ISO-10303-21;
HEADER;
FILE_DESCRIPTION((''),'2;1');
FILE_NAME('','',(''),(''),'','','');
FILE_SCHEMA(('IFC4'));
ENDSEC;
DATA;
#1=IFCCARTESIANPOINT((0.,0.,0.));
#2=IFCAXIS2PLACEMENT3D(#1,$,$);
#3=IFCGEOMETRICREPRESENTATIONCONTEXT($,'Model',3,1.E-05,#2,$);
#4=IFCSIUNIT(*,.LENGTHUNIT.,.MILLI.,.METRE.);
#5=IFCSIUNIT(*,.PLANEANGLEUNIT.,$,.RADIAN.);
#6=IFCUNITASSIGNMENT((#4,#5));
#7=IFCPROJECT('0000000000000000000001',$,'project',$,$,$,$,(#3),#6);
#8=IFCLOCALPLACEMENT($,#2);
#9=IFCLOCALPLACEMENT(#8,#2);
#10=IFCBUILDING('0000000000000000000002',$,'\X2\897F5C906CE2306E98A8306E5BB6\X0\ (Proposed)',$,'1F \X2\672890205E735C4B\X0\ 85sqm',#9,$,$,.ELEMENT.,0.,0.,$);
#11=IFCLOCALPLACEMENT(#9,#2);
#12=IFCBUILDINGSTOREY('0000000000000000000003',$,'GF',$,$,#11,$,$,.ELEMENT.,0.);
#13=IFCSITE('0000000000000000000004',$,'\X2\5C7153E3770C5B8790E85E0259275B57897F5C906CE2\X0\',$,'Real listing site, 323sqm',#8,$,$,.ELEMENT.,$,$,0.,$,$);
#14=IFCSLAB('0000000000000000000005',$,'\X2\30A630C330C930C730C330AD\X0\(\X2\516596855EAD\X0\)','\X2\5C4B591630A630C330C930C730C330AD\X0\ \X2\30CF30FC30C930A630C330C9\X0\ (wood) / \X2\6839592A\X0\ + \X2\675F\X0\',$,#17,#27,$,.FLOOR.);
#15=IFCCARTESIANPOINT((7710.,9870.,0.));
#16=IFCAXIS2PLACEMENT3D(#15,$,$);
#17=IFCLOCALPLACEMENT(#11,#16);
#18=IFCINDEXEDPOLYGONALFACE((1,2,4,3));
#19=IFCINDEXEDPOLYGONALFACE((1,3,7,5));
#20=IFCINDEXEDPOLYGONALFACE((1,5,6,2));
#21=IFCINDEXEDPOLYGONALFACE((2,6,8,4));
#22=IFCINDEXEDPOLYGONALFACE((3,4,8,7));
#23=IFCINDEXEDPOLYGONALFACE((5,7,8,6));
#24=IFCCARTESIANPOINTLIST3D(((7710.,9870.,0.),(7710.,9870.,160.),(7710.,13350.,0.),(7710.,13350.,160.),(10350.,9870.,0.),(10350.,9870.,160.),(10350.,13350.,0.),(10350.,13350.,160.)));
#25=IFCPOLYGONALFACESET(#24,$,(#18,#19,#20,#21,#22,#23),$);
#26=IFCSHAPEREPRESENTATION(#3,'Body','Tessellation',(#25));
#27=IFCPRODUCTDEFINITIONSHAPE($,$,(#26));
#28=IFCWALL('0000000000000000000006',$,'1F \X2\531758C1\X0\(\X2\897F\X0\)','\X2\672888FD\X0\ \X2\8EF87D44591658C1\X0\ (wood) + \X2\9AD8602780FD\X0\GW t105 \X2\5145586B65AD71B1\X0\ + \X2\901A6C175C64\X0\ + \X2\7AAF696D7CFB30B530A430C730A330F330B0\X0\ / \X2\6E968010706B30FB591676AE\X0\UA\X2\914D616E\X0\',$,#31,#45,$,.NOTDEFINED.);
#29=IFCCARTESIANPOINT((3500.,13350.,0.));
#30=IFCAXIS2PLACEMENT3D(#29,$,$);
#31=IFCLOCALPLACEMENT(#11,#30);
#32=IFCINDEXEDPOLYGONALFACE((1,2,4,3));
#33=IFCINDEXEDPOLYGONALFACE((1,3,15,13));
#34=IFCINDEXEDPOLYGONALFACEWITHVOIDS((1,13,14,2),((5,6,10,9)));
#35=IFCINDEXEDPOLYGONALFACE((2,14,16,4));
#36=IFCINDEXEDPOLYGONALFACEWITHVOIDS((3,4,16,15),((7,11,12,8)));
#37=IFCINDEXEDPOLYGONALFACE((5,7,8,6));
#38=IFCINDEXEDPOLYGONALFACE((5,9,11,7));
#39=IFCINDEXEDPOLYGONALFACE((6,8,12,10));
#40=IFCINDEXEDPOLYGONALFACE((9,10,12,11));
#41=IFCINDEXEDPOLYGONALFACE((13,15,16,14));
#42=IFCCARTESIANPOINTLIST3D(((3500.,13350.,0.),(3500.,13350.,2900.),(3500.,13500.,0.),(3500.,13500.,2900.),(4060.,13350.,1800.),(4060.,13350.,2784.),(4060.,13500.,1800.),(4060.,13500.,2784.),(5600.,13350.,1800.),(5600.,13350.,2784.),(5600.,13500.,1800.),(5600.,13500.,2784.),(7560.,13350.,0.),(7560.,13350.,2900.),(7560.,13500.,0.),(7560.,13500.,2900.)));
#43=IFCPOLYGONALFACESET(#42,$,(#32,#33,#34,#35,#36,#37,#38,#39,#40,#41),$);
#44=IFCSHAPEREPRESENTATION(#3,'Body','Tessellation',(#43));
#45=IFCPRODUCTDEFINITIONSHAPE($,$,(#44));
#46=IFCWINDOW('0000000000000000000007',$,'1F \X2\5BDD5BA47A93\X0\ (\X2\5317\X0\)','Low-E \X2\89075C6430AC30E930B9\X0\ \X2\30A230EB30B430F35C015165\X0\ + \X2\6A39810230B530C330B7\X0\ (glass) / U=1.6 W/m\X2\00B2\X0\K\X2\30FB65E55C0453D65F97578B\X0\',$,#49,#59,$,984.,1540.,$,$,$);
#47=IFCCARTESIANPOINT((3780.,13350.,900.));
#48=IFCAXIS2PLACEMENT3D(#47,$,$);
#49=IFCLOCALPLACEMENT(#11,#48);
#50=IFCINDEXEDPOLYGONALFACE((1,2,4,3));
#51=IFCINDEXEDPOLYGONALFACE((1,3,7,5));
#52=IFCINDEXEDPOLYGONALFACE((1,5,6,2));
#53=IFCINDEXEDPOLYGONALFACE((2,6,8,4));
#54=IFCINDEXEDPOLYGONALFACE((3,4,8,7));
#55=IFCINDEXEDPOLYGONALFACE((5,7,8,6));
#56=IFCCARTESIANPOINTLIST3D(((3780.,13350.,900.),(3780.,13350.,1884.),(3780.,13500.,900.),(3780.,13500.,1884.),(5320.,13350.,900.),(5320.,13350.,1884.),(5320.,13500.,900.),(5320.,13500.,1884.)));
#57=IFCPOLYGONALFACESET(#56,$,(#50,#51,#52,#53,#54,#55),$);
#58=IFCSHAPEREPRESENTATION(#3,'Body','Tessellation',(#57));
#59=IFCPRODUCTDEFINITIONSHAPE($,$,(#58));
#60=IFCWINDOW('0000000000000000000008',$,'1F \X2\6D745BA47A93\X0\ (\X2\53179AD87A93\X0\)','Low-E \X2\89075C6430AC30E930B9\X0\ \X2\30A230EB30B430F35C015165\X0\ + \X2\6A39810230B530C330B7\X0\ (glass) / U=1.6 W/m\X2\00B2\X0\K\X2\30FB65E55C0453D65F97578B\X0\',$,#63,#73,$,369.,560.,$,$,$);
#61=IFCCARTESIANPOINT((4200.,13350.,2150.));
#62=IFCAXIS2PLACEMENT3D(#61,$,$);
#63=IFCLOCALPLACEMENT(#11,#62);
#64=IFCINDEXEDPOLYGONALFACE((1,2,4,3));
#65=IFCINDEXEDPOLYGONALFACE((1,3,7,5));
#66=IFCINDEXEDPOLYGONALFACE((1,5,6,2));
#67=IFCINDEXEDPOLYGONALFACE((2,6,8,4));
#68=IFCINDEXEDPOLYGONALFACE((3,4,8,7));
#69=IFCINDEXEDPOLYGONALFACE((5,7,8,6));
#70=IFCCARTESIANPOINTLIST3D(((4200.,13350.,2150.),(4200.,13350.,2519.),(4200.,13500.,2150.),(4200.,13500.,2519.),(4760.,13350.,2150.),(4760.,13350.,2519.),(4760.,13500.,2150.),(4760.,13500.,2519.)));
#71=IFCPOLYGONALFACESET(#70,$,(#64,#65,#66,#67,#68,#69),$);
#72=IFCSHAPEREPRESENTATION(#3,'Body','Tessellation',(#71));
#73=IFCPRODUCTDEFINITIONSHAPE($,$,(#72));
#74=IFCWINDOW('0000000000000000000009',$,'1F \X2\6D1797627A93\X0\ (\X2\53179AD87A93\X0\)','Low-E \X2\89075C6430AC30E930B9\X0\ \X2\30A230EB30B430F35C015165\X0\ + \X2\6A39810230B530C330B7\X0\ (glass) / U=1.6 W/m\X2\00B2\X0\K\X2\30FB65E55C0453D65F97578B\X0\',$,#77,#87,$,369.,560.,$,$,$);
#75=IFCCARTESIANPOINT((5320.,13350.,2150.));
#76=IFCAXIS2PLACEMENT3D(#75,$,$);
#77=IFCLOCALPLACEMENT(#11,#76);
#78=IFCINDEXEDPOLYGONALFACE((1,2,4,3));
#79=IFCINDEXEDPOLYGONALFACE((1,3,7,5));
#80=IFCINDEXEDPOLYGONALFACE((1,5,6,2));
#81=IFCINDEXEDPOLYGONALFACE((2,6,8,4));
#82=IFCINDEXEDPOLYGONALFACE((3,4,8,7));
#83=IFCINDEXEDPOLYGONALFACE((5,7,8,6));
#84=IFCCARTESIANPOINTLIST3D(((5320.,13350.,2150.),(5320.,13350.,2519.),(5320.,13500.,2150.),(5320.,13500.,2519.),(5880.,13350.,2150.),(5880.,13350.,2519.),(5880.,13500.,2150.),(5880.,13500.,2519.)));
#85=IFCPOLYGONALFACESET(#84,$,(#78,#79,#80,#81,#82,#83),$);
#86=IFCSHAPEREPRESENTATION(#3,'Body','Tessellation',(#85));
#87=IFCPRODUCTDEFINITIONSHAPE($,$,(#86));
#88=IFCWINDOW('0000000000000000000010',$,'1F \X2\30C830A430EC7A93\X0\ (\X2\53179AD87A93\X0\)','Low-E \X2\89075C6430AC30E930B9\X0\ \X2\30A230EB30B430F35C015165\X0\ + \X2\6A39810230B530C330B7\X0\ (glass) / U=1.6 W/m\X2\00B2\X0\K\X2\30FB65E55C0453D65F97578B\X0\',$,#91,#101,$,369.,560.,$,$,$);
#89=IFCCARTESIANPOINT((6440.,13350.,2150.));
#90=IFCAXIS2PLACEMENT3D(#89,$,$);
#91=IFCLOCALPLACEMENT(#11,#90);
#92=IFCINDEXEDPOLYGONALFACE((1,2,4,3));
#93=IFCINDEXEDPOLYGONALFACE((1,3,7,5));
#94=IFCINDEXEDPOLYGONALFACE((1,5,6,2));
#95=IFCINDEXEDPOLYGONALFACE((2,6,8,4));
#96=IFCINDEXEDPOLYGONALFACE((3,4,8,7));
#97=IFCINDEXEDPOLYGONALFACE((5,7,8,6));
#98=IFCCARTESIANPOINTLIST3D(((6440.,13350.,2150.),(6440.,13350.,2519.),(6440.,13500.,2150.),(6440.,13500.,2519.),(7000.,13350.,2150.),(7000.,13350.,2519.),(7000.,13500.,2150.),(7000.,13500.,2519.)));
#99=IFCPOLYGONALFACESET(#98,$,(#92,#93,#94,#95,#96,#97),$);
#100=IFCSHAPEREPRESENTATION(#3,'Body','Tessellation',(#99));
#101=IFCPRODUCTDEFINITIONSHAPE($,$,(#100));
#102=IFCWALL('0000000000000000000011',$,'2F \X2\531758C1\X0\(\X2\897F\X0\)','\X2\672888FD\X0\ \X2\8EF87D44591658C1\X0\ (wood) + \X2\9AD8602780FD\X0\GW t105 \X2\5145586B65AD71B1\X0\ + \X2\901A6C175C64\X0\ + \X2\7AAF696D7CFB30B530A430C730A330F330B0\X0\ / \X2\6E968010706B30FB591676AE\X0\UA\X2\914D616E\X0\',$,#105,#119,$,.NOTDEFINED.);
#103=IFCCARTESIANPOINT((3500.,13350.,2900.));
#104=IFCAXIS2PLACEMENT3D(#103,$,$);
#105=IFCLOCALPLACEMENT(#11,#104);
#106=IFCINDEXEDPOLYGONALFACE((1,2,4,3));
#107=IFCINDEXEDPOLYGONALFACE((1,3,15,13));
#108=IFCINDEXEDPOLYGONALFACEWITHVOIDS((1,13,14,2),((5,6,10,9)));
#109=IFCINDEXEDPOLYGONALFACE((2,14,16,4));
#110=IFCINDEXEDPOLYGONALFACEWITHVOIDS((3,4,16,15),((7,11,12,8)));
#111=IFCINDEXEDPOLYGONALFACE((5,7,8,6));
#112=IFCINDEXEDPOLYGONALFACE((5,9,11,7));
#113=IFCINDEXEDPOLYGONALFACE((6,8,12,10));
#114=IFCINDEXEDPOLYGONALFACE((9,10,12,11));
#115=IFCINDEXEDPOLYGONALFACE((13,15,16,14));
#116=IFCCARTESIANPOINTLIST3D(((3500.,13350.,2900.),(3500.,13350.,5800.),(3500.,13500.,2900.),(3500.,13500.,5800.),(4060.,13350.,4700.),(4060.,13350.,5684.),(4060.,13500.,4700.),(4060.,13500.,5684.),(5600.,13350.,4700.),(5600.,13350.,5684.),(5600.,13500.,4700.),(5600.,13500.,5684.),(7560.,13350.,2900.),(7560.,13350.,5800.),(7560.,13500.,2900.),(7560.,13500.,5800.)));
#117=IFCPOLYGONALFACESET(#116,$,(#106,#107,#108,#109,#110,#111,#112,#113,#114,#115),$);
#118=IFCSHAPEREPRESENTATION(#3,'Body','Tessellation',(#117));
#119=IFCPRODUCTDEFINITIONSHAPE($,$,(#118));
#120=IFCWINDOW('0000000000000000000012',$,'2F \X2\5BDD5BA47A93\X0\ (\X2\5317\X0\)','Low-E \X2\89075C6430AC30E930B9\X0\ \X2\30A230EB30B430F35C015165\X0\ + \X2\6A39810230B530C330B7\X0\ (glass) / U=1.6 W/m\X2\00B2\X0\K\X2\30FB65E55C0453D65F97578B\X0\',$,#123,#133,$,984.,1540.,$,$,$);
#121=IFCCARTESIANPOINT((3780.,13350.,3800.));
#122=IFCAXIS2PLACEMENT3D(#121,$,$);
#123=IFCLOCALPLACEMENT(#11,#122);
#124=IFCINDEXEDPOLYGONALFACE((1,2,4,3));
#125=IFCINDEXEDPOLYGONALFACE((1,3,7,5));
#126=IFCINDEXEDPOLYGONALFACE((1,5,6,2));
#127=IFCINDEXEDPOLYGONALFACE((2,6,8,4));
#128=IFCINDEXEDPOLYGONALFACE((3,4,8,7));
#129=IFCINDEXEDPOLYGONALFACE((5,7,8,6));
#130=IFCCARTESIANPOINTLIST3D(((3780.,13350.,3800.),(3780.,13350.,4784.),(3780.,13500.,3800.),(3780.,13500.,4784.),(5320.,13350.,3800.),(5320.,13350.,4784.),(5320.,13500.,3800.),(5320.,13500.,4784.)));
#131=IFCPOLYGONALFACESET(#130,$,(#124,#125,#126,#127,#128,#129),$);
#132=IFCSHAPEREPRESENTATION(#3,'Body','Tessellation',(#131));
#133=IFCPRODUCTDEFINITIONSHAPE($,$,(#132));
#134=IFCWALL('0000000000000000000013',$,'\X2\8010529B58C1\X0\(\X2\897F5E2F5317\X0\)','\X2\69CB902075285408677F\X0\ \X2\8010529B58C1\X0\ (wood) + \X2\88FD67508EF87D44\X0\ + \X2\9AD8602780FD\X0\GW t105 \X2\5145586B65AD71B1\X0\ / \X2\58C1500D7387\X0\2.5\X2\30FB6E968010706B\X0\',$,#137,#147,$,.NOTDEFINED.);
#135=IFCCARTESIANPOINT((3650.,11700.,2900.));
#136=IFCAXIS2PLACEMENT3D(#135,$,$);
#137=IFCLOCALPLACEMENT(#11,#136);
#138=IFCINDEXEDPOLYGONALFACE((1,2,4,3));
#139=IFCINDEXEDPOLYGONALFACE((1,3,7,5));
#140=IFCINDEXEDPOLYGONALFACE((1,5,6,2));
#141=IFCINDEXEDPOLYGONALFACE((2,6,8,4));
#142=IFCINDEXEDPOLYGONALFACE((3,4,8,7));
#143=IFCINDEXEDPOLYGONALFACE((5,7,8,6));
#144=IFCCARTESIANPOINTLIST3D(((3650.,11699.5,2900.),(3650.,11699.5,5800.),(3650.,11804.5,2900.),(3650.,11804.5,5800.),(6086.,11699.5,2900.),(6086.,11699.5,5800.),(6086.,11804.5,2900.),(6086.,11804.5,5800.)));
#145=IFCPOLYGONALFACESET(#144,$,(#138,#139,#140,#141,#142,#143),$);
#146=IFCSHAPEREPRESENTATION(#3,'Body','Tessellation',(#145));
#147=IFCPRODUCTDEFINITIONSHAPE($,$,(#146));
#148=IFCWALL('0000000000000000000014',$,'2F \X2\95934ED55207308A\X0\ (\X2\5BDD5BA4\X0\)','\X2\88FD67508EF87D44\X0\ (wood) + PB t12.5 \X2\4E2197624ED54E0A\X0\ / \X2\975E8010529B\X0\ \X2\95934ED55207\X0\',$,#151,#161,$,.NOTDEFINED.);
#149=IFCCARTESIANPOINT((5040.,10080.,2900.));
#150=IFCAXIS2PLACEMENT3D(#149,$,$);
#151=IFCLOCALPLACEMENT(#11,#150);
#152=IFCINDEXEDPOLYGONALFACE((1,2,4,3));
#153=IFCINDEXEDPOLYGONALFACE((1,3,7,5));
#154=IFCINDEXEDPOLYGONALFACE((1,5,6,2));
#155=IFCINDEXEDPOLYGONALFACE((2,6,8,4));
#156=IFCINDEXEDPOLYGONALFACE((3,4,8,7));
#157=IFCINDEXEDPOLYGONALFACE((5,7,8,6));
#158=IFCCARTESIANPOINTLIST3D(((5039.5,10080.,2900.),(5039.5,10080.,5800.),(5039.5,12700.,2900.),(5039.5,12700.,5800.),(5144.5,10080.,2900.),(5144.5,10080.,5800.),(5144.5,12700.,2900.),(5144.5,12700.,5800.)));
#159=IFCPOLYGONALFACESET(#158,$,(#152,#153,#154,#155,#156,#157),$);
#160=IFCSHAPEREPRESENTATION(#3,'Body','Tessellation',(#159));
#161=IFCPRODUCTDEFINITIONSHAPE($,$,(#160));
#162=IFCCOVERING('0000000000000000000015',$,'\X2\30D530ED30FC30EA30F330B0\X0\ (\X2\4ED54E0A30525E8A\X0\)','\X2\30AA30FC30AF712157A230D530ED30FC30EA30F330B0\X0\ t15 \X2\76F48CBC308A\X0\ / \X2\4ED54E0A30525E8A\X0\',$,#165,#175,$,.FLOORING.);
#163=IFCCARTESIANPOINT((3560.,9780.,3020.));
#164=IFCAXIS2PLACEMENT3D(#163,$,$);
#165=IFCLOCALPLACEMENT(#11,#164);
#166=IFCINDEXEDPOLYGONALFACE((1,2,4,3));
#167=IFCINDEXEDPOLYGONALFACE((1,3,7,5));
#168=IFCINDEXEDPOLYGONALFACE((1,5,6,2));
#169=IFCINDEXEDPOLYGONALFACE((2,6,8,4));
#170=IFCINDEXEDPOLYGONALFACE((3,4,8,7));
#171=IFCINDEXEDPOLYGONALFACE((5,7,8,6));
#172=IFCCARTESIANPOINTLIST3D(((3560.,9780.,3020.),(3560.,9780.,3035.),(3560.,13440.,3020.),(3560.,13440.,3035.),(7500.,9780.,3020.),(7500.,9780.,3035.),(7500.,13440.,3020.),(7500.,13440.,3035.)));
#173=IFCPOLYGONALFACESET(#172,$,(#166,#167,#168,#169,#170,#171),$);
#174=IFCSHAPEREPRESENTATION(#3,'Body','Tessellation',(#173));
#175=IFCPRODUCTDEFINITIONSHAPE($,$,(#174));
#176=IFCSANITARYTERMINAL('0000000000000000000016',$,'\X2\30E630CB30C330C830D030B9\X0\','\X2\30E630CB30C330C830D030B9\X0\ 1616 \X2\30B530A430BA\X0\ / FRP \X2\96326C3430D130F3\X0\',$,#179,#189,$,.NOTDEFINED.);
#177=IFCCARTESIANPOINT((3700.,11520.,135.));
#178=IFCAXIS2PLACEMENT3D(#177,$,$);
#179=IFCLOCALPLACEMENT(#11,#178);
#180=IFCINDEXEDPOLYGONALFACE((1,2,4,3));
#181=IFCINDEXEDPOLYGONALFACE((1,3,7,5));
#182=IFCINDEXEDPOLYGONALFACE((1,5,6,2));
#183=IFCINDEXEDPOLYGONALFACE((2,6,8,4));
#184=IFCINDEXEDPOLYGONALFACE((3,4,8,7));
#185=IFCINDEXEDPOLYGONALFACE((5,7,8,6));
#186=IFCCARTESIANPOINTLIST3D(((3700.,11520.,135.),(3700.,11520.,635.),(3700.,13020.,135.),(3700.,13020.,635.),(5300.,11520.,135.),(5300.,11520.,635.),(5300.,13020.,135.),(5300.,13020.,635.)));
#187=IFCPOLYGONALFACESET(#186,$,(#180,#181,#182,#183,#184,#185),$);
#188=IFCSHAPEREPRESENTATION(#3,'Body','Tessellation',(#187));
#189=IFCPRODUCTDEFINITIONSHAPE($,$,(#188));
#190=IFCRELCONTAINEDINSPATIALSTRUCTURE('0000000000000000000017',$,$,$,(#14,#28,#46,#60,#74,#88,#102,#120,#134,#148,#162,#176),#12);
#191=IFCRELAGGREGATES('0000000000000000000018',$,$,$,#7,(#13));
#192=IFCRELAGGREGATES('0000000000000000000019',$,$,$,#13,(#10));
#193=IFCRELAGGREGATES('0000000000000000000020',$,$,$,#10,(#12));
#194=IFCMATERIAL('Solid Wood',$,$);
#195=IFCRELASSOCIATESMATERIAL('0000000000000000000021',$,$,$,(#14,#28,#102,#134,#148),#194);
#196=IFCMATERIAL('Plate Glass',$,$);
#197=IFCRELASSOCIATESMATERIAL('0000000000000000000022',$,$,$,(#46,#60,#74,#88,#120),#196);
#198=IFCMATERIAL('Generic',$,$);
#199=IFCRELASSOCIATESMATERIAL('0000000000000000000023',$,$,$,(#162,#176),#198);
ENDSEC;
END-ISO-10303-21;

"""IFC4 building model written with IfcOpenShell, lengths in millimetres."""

from ifc_helpers import new_model, si_unit, frame, frame_2d, origin, place, context, project, spatial, rectangle, extrude, material, element, fill, save


model = new_model("IFC4")

# Units and contexts
model_context = context("Model", 3, precision=1e-05, world=origin())
ifc_project = project(units=[si_unit("LENGTHUNIT", "METRE", prefix="MILLI"), si_unit("PLANEANGLEUNIT", "RADIAN")], contexts=[model_context])

# Site, building, storey
site_placement = place(None, origin())
site = spatial("IfcSite", under=ifc_project, at=site_placement, Name="山口県宇部市大字西岐波", ObjectType="Real listing site, 323sqm", CompositionType="ELEMENT", RefElevation=0.0)
building_placement = place(site_placement, origin())
building = spatial("IfcBuilding", under=site, at=building_placement, Name="西岐波の風の家 (Proposed)", ObjectType="1F 木造平屋 85sqm", CompositionType="ELEMENT", ElevationOfRefHeight=0.0, ElevationOfTerrain=0.0)
storey_placement = place(building_placement, origin())
storey = spatial("IfcBuildingStorey", under=building, at=storey_placement, Name="GF", CompositionType="ELEMENT", Elevation=0.0)

# Slab
ifc_material_1 = material(Name="Solid Wood")
slab_placement = place(storey_placement, frame((7710.0, 9870.0, 0.0)))
element("IfcSlab", 1, at=slab_placement, inside=storey, material=ifc_material_1, Name="ウッドデッキ(入隅庭)", Description="屋外ウッドデッキ ハードウッド (wood) / 根太 + 束", PredefinedType="FLOOR", context=model_context, shape_type="SweptSolid", body=[
    extrude(rectangle(XDim=2640.0, YDim=3480.0, at=frame_2d((1320.0, 1740.0))), frame((7710.0, 9870.0, 0.0)), (0.0, 0.0, 1.0), 160.0),
])

# Wall, openings, windows
wall_1_placement = place(storey_placement, frame((3500.0, 13350.0, 0.0)))
wall_1 = element("IfcWall", 2, at=wall_1_placement, inside=storey, material=ifc_material_1, Name="1F 北壁(西)", Description="木製 軸組外壁 (wood) + 高性能GW t105 充填断熱 + 通気層 + 窯業系サイディング / 準耐火・外皮UA配慮", PredefinedType="NOTDEFINED", context=model_context, shape_type="SweptSolid", body=[
    extrude(rectangle(XDim=4060.0, YDim=150.0, at=frame_2d((2030.0, 75.0))), frame((3500.0, 13350.0, 0.0)), (0.0, 0.0, 1.0), 2900.0),
])
opening_1_placement = place(storey_placement, frame((3780.0, 13350.0, 900.0)))
opening_1 = element("IfcOpeningElement", 3, at=opening_1_placement, cuts=wall_1, PredefinedType="NOTDEFINED", context=model_context, shape_type="SweptSolid", body=[
    extrude(rectangle(XDim=1540.0, YDim=150.0, at=frame_2d((770.0, 75.0))), frame((3780.0, 13350.0, 900.0)), (0.0, 0.0, 1.0), 984.0),
])
opening_2_placement = place(storey_placement, frame((4200.0, 13350.0, 2150.0)))
opening_2 = element("IfcOpeningElement", 4, at=opening_2_placement, cuts=wall_1, PredefinedType="NOTDEFINED", context=model_context, shape_type="SweptSolid", body=[
    extrude(rectangle(XDim=560.0, YDim=150.0, at=frame_2d((280.0, 75.0))), frame((4200.0, 13350.0, 2150.0)), (0.0, 0.0, 1.0), 369.0),
])
opening_3_placement = place(storey_placement, frame((5320.0, 13350.0, 2150.0)))
opening_3 = element("IfcOpeningElement", 5, at=opening_3_placement, cuts=wall_1, PredefinedType="NOTDEFINED", context=model_context, shape_type="SweptSolid", body=[
    extrude(rectangle(XDim=560.0, YDim=150.0, at=frame_2d((280.0, 75.0))), frame((5320.0, 13350.0, 2150.0)), (0.0, 0.0, 1.0), 369.0),
])
opening_4_placement = place(storey_placement, frame((6440.0, 13350.0, 2150.0)))
opening_4 = element("IfcOpeningElement", 6, at=opening_4_placement, cuts=wall_1, PredefinedType="NOTDEFINED", context=model_context, shape_type="SweptSolid", body=[
    extrude(rectangle(XDim=560.0, YDim=150.0, at=frame_2d((280.0, 75.0))), frame((6440.0, 13350.0, 2150.0)), (0.0, 0.0, 1.0), 369.0),
])
ifc_material_2 = material(Name="Plate Glass")
window_1_placement = place(storey_placement, frame((3780.0, 13350.0, 900.0)))
window_1 = element("IfcWindow", 7, at=window_1_placement, inside=storey, material=ifc_material_2, Name="1F 寝室窓 (北)", Description="Low-E 複層ガラス アルゴン封入 + 樹脂サッシ (glass) / U=1.6 W/m²K・日射取得型", OverallHeight=984.0, OverallWidth=1540.0, context=model_context, shape_type="SweptSolid", body=[
    extrude(rectangle(XDim=1540.0, YDim=150.0, at=frame_2d((770.0, 75.0))), frame((3780.0, 13350.0, 900.0)), (0.0, 0.0, 1.0), 984.0),
])
fill(opening_1, window_1)
window_2_placement = place(storey_placement, frame((4200.0, 13350.0, 2150.0)))
window_2 = element("IfcWindow", 8, at=window_2_placement, inside=storey, material=ifc_material_2, Name="1F 浴室窓 (北高窓)", Description="Low-E 複層ガラス アルゴン封入 + 樹脂サッシ (glass) / U=1.6 W/m²K・日射取得型", OverallHeight=369.0, OverallWidth=560.0, context=model_context, shape_type="SweptSolid", body=[
    extrude(rectangle(XDim=560.0, YDim=150.0, at=frame_2d((280.0, 75.0))), frame((4200.0, 13350.0, 2150.0)), (0.0, 0.0, 1.0), 369.0),
])
fill(opening_2, window_2)
window_3_placement = place(storey_placement, frame((5320.0, 13350.0, 2150.0)))
window_3 = element("IfcWindow", 9, at=window_3_placement, inside=storey, material=ifc_material_2, Name="1F 洗面窓 (北高窓)", Description="Low-E 複層ガラス アルゴン封入 + 樹脂サッシ (glass) / U=1.6 W/m²K・日射取得型", OverallHeight=369.0, OverallWidth=560.0, context=model_context, shape_type="SweptSolid", body=[
    extrude(rectangle(XDim=560.0, YDim=150.0, at=frame_2d((280.0, 75.0))), frame((5320.0, 13350.0, 2150.0)), (0.0, 0.0, 1.0), 369.0),
])
fill(opening_3, window_3)
window_4_placement = place(storey_placement, frame((6440.0, 13350.0, 2150.0)))
window_4 = element("IfcWindow", 10, at=window_4_placement, inside=storey, material=ifc_material_2, Name="1F トイレ窓 (北高窓)", Description="Low-E 複層ガラス アルゴン封入 + 樹脂サッシ (glass) / U=1.6 W/m²K・日射取得型", OverallHeight=369.0, OverallWidth=560.0, context=model_context, shape_type="SweptSolid", body=[
    extrude(rectangle(XDim=560.0, YDim=150.0, at=frame_2d((280.0, 75.0))), frame((6440.0, 13350.0, 2150.0)), (0.0, 0.0, 1.0), 369.0),
])
fill(opening_4, window_4)

# Wall, opening, window
wall_2_placement = place(storey_placement, frame((3500.0, 13350.0, 2900.0)))
wall_2 = element("IfcWall", 11, at=wall_2_placement, inside=storey, material=ifc_material_1, Name="2F 北壁(西)", Description="木製 軸組外壁 (wood) + 高性能GW t105 充填断熱 + 通気層 + 窯業系サイディング / 準耐火・外皮UA配慮", PredefinedType="NOTDEFINED", context=model_context, shape_type="SweptSolid", body=[
    extrude(rectangle(XDim=4060.0, YDim=150.0, at=frame_2d((2030.0, 75.0))), frame((3500.0, 13350.0, 2900.0)), (0.0, 0.0, 1.0), 2900.0),
])
opening_5_placement = place(storey_placement, frame((3780.0, 13350.0, 3800.0)))
opening_5 = element("IfcOpeningElement", 12, at=opening_5_placement, cuts=wall_2, PredefinedType="NOTDEFINED", context=model_context, shape_type="SweptSolid", body=[
    extrude(rectangle(XDim=1540.0, YDim=150.0, at=frame_2d((770.0, 75.0))), frame((3780.0, 13350.0, 3800.0)), (0.0, 0.0, 1.0), 984.0),
])
window_5_placement = place(storey_placement, frame((3780.0, 13350.0, 3800.0)))
window_5 = element("IfcWindow", 13, at=window_5_placement, inside=storey, material=ifc_material_2, Name="2F 寝室窓 (北)", Description="Low-E 複層ガラス アルゴン封入 + 樹脂サッシ (glass) / U=1.6 W/m²K・日射取得型", OverallHeight=984.0, OverallWidth=1540.0, context=model_context, shape_type="SweptSolid", body=[
    extrude(rectangle(XDim=1540.0, YDim=150.0, at=frame_2d((770.0, 75.0))), frame((3780.0, 13350.0, 3800.0)), (0.0, 0.0, 1.0), 984.0),
])
fill(opening_5, window_5)

# Walls
wall_3_placement = place(storey_placement, frame((3650.0, 11700.0, 2900.0)))
element("IfcWall", 14, at=wall_3_placement, inside=storey, material=ifc_material_1, Name="耐力壁(西帯北)", Description="構造用合板 耐力壁 (wood) + 製材軸組 + 高性能GW t105 充填断熱 / 壁倍率2.5・準耐火", PredefinedType="NOTDEFINED", context=model_context, shape_type="SweptSolid", body=[
    extrude(rectangle(XDim=2436.0, YDim=105.0, at=frame_2d((1218.0, 52.0))), frame((3650.0, 11700.0, 2900.0)), (0.0, 0.0, 1.0), 2900.0),
])
wall_4_placement = place(storey_placement, frame((5040.0, 10080.0, 2900.0)))
element("IfcWall", 15, at=wall_4_placement, inside=storey, material=ifc_material_1, Name="2F 間仕切り (寝室)", Description="製材軸組 (wood) + PB t12.5 両面仕上 / 非耐力 間仕切", PredefinedType="NOTDEFINED", context=model_context, shape_type="SweptSolid", body=[
    extrude(rectangle(XDim=105.0, YDim=2620.0, at=frame_2d((52.0, 1310.0))), frame((5040.0, 10080.0, 2900.0)), (0.0, 0.0, 1.0), 2900.0),
])

# Covering
ifc_material_3 = material(Name="Generic")
covering_placement = place(storey_placement, frame((3560.0, 9780.0, 3020.0)))
element("IfcCovering", 16, at=covering_placement, inside=storey, material=ifc_material_3, Name="フローリング (仕上げ床)", Description="オーク無垢フローリング t15 直貼り / 仕上げ床", PredefinedType="FLOORING", context=model_context, shape_type="SweptSolid", body=[
    extrude(rectangle(XDim=3940.0, YDim=3660.0, at=frame_2d((1970.0, 1830.0))), frame((3560.0, 9780.0, 3020.0)), (0.0, 0.0, 1.0), 15.0),
])

# Sanitary terminal
sanitary_terminal_1_placement = place(storey_placement, frame((3700.0, 11520.0, 135.0)))
element("IfcSanitaryTerminal", 17, at=sanitary_terminal_1_placement, inside=storey, material=ifc_material_3, Name="ユニットバス", Description="ユニットバス 1616 サイズ / FRP 防水パン", PredefinedType="NOTDEFINED", context=model_context, shape_type="SweptSolid", body=[
    extrude(rectangle(XDim=1600.0, YDim=1500.0, at=frame_2d((800.0, 750.0))), frame((3700.0, 11520.0, 135.0)), (0.0, 0.0, 1.0), 500.0),
])

save(model, "model.ifc")
